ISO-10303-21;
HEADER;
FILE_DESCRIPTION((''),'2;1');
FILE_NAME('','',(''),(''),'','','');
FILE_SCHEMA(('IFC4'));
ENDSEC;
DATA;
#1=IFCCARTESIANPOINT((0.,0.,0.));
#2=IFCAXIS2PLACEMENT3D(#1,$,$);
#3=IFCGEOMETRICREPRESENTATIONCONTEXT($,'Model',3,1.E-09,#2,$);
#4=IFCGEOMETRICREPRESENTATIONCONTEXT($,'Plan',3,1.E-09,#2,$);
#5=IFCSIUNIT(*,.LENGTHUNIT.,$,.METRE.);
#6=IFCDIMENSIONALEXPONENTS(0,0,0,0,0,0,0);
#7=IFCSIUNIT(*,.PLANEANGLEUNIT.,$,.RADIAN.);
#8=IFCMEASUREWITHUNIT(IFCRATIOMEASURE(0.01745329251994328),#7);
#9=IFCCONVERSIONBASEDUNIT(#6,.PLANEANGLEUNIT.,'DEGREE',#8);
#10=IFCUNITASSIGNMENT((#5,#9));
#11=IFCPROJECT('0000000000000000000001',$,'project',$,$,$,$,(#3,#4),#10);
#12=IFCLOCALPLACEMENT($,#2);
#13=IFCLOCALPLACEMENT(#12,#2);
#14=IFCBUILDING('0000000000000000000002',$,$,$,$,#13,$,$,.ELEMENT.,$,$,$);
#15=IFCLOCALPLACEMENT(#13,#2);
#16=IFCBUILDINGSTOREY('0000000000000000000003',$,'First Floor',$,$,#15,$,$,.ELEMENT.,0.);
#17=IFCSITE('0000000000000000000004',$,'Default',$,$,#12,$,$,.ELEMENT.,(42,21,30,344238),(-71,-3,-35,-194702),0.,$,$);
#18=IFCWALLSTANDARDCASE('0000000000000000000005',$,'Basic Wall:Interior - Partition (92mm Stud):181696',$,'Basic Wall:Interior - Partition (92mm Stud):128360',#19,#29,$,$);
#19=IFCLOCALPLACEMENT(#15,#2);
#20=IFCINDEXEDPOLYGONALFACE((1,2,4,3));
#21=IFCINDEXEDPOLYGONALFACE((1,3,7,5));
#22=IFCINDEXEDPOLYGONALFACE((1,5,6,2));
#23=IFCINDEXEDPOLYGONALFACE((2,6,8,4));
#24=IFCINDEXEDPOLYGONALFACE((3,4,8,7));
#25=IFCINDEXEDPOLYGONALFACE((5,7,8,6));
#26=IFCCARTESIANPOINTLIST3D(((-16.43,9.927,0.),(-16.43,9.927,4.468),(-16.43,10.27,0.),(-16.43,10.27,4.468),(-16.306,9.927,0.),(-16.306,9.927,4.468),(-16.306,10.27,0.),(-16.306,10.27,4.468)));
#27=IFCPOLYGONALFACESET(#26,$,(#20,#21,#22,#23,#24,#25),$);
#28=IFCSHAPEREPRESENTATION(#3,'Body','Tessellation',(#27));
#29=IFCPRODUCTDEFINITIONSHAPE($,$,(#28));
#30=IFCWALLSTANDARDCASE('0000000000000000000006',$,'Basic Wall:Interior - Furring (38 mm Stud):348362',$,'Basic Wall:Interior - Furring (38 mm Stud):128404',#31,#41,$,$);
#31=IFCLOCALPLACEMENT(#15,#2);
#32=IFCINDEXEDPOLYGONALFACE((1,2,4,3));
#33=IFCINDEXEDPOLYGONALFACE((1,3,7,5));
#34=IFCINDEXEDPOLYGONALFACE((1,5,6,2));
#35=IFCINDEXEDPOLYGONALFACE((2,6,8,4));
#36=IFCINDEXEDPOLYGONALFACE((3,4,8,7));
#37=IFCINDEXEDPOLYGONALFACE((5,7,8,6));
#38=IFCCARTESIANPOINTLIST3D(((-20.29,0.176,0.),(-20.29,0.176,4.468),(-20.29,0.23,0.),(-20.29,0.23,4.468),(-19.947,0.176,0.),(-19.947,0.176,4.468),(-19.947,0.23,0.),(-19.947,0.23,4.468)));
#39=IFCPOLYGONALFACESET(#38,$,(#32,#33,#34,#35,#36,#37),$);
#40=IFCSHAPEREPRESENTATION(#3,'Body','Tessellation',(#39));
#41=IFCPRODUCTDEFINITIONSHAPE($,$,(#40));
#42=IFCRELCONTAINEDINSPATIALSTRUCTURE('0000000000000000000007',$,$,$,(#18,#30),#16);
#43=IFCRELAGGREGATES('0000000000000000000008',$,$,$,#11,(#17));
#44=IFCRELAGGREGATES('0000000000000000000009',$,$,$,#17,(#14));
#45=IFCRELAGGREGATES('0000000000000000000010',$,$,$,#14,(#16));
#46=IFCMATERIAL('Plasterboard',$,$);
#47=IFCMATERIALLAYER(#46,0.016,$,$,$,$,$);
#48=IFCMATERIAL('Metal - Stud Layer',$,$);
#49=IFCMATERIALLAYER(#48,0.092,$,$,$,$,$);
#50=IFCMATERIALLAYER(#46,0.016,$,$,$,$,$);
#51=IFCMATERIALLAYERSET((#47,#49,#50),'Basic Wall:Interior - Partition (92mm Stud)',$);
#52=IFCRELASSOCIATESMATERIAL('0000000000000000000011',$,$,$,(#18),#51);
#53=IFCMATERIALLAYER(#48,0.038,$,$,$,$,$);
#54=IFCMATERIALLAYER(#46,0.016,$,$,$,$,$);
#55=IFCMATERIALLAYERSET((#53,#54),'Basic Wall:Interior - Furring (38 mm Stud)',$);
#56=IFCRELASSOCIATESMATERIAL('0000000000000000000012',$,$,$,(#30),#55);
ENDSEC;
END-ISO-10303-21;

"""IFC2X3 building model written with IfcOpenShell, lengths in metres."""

from ifc_helpers import new_model, entity, si_unit, converted_unit, frame, frame_2d, origin, place, context, project, spatial, rectangle, extrude, material, layer, layer_set, layer_usage, element, save


model = new_model("IFC2X3")

# Units and contexts
model_context = context("Model", 3, precision=1e-09, world=origin())
plan_context = context("Plan", 3, precision=1e-09, world=origin())
ifc_project = project(units=[si_unit("LENGTHUNIT", "METRE"), converted_unit("PLANEANGLEUNIT", "DEGREE", entity("IfcRatioMeasure", 0.01745329251994328), si_unit("PLANEANGLEUNIT", "RADIAN"), dimensions=[0, 0, 0, 0, 0, 0, 0])], contexts=[model_context, plan_context])

# Site, building, storey
site_placement = place(None, origin())
site = spatial("IfcSite", under=ifc_project, at=site_placement, Name="Default", CompositionType="ELEMENT", RefLatitude=(42, 21, 30, 344238), RefLongitude=(-71, -3, -35, -194702), RefElevation=0.0)
building_placement = place(site_placement, origin())
building = spatial("IfcBuilding", under=site, at=building_placement, CompositionType="ELEMENT")
storey_placement = place(building_placement, origin())
storey = spatial("IfcBuildingStorey", under=building, at=storey_placement, Name="First Floor", CompositionType="ELEMENT", Elevation=0.0)

# Shared definitions
ifc_material_1 = material(Name="Metal - Stud Layer")
ifc_material_2 = material(Name="Plasterboard")

# Shared definitions
ifc_layer_1 = layer(ifc_material_2, 0.016)
ifc_layer_2 = layer(ifc_material_1, 0.092)
ifc_layer_3 = layer(ifc_material_2, 0.016)
ifc_layer_set_1 = layer_set([ifc_layer_1, ifc_layer_2, ifc_layer_3], Name="Basic Wall:Interior - Partition (92mm Stud)")
ifc_layer_usage_1 = layer_usage(ifc_layer_set_1, "AXIS2", "NEGATIVE", 0.062)

# Walls
ifc_layer_4 = layer(ifc_material_1, 0.038)
ifc_layer_5 = layer(ifc_material_2, 0.016)
ifc_layer_set_2 = layer_set([ifc_layer_4, ifc_layer_5], Name="Basic Wall:Interior - Furring (38 mm Stud)")
wall_1_placement = place(storey_placement, frame((-16.368, 9.927, 0.0), z_axis=(0.0, 0.0, 1.0), x_axis=(0.0, 1.0, 0.0)))
element("IfcWallStandardCase", 1, at=wall_1_placement, inside=storey, material=ifc_layer_usage_1, Name="Basic Wall:Interior - Partition (92mm Stud):181696", ObjectType="Basic Wall:Interior - Partition (92mm Stud):128360", context=model_context, shape_type="SweptSolid", body=[
    extrude(rectangle(XDim=0.343, YDim=0.124, at=frame_2d((0.1715, 0.0), x_axis=(-1.0, 0.0))), origin(), (0.0, 0.0, 1.0), 4.468),
])
ifc_layer_usage_2 = layer_usage(ifc_layer_set_2, "AXIS2", "NEGATIVE", 0.027)
wall_2_placement = place(storey_placement, frame((-19.947, 0.203, 0.0), z_axis=(0.0, 0.0, 1.0), x_axis=(-1.0, 0.0, 0.0)))
element("IfcWallStandardCase", 2, at=wall_2_placement, inside=storey, material=ifc_layer_usage_2, Name="Basic Wall:Interior - Furring (38 mm Stud):348362", ObjectType="Basic Wall:Interior - Furring (38 mm Stud):128404", context=model_context, shape_type="SweptSolid", body=[
    extrude(rectangle(XDim=0.343, YDim=0.054, at=frame_2d((0.1715, 0.0), x_axis=(-1.0, 0.0))), origin(), (0.0, 0.0, 1.0), 4.468),
])

save(model, "model.ifc")
